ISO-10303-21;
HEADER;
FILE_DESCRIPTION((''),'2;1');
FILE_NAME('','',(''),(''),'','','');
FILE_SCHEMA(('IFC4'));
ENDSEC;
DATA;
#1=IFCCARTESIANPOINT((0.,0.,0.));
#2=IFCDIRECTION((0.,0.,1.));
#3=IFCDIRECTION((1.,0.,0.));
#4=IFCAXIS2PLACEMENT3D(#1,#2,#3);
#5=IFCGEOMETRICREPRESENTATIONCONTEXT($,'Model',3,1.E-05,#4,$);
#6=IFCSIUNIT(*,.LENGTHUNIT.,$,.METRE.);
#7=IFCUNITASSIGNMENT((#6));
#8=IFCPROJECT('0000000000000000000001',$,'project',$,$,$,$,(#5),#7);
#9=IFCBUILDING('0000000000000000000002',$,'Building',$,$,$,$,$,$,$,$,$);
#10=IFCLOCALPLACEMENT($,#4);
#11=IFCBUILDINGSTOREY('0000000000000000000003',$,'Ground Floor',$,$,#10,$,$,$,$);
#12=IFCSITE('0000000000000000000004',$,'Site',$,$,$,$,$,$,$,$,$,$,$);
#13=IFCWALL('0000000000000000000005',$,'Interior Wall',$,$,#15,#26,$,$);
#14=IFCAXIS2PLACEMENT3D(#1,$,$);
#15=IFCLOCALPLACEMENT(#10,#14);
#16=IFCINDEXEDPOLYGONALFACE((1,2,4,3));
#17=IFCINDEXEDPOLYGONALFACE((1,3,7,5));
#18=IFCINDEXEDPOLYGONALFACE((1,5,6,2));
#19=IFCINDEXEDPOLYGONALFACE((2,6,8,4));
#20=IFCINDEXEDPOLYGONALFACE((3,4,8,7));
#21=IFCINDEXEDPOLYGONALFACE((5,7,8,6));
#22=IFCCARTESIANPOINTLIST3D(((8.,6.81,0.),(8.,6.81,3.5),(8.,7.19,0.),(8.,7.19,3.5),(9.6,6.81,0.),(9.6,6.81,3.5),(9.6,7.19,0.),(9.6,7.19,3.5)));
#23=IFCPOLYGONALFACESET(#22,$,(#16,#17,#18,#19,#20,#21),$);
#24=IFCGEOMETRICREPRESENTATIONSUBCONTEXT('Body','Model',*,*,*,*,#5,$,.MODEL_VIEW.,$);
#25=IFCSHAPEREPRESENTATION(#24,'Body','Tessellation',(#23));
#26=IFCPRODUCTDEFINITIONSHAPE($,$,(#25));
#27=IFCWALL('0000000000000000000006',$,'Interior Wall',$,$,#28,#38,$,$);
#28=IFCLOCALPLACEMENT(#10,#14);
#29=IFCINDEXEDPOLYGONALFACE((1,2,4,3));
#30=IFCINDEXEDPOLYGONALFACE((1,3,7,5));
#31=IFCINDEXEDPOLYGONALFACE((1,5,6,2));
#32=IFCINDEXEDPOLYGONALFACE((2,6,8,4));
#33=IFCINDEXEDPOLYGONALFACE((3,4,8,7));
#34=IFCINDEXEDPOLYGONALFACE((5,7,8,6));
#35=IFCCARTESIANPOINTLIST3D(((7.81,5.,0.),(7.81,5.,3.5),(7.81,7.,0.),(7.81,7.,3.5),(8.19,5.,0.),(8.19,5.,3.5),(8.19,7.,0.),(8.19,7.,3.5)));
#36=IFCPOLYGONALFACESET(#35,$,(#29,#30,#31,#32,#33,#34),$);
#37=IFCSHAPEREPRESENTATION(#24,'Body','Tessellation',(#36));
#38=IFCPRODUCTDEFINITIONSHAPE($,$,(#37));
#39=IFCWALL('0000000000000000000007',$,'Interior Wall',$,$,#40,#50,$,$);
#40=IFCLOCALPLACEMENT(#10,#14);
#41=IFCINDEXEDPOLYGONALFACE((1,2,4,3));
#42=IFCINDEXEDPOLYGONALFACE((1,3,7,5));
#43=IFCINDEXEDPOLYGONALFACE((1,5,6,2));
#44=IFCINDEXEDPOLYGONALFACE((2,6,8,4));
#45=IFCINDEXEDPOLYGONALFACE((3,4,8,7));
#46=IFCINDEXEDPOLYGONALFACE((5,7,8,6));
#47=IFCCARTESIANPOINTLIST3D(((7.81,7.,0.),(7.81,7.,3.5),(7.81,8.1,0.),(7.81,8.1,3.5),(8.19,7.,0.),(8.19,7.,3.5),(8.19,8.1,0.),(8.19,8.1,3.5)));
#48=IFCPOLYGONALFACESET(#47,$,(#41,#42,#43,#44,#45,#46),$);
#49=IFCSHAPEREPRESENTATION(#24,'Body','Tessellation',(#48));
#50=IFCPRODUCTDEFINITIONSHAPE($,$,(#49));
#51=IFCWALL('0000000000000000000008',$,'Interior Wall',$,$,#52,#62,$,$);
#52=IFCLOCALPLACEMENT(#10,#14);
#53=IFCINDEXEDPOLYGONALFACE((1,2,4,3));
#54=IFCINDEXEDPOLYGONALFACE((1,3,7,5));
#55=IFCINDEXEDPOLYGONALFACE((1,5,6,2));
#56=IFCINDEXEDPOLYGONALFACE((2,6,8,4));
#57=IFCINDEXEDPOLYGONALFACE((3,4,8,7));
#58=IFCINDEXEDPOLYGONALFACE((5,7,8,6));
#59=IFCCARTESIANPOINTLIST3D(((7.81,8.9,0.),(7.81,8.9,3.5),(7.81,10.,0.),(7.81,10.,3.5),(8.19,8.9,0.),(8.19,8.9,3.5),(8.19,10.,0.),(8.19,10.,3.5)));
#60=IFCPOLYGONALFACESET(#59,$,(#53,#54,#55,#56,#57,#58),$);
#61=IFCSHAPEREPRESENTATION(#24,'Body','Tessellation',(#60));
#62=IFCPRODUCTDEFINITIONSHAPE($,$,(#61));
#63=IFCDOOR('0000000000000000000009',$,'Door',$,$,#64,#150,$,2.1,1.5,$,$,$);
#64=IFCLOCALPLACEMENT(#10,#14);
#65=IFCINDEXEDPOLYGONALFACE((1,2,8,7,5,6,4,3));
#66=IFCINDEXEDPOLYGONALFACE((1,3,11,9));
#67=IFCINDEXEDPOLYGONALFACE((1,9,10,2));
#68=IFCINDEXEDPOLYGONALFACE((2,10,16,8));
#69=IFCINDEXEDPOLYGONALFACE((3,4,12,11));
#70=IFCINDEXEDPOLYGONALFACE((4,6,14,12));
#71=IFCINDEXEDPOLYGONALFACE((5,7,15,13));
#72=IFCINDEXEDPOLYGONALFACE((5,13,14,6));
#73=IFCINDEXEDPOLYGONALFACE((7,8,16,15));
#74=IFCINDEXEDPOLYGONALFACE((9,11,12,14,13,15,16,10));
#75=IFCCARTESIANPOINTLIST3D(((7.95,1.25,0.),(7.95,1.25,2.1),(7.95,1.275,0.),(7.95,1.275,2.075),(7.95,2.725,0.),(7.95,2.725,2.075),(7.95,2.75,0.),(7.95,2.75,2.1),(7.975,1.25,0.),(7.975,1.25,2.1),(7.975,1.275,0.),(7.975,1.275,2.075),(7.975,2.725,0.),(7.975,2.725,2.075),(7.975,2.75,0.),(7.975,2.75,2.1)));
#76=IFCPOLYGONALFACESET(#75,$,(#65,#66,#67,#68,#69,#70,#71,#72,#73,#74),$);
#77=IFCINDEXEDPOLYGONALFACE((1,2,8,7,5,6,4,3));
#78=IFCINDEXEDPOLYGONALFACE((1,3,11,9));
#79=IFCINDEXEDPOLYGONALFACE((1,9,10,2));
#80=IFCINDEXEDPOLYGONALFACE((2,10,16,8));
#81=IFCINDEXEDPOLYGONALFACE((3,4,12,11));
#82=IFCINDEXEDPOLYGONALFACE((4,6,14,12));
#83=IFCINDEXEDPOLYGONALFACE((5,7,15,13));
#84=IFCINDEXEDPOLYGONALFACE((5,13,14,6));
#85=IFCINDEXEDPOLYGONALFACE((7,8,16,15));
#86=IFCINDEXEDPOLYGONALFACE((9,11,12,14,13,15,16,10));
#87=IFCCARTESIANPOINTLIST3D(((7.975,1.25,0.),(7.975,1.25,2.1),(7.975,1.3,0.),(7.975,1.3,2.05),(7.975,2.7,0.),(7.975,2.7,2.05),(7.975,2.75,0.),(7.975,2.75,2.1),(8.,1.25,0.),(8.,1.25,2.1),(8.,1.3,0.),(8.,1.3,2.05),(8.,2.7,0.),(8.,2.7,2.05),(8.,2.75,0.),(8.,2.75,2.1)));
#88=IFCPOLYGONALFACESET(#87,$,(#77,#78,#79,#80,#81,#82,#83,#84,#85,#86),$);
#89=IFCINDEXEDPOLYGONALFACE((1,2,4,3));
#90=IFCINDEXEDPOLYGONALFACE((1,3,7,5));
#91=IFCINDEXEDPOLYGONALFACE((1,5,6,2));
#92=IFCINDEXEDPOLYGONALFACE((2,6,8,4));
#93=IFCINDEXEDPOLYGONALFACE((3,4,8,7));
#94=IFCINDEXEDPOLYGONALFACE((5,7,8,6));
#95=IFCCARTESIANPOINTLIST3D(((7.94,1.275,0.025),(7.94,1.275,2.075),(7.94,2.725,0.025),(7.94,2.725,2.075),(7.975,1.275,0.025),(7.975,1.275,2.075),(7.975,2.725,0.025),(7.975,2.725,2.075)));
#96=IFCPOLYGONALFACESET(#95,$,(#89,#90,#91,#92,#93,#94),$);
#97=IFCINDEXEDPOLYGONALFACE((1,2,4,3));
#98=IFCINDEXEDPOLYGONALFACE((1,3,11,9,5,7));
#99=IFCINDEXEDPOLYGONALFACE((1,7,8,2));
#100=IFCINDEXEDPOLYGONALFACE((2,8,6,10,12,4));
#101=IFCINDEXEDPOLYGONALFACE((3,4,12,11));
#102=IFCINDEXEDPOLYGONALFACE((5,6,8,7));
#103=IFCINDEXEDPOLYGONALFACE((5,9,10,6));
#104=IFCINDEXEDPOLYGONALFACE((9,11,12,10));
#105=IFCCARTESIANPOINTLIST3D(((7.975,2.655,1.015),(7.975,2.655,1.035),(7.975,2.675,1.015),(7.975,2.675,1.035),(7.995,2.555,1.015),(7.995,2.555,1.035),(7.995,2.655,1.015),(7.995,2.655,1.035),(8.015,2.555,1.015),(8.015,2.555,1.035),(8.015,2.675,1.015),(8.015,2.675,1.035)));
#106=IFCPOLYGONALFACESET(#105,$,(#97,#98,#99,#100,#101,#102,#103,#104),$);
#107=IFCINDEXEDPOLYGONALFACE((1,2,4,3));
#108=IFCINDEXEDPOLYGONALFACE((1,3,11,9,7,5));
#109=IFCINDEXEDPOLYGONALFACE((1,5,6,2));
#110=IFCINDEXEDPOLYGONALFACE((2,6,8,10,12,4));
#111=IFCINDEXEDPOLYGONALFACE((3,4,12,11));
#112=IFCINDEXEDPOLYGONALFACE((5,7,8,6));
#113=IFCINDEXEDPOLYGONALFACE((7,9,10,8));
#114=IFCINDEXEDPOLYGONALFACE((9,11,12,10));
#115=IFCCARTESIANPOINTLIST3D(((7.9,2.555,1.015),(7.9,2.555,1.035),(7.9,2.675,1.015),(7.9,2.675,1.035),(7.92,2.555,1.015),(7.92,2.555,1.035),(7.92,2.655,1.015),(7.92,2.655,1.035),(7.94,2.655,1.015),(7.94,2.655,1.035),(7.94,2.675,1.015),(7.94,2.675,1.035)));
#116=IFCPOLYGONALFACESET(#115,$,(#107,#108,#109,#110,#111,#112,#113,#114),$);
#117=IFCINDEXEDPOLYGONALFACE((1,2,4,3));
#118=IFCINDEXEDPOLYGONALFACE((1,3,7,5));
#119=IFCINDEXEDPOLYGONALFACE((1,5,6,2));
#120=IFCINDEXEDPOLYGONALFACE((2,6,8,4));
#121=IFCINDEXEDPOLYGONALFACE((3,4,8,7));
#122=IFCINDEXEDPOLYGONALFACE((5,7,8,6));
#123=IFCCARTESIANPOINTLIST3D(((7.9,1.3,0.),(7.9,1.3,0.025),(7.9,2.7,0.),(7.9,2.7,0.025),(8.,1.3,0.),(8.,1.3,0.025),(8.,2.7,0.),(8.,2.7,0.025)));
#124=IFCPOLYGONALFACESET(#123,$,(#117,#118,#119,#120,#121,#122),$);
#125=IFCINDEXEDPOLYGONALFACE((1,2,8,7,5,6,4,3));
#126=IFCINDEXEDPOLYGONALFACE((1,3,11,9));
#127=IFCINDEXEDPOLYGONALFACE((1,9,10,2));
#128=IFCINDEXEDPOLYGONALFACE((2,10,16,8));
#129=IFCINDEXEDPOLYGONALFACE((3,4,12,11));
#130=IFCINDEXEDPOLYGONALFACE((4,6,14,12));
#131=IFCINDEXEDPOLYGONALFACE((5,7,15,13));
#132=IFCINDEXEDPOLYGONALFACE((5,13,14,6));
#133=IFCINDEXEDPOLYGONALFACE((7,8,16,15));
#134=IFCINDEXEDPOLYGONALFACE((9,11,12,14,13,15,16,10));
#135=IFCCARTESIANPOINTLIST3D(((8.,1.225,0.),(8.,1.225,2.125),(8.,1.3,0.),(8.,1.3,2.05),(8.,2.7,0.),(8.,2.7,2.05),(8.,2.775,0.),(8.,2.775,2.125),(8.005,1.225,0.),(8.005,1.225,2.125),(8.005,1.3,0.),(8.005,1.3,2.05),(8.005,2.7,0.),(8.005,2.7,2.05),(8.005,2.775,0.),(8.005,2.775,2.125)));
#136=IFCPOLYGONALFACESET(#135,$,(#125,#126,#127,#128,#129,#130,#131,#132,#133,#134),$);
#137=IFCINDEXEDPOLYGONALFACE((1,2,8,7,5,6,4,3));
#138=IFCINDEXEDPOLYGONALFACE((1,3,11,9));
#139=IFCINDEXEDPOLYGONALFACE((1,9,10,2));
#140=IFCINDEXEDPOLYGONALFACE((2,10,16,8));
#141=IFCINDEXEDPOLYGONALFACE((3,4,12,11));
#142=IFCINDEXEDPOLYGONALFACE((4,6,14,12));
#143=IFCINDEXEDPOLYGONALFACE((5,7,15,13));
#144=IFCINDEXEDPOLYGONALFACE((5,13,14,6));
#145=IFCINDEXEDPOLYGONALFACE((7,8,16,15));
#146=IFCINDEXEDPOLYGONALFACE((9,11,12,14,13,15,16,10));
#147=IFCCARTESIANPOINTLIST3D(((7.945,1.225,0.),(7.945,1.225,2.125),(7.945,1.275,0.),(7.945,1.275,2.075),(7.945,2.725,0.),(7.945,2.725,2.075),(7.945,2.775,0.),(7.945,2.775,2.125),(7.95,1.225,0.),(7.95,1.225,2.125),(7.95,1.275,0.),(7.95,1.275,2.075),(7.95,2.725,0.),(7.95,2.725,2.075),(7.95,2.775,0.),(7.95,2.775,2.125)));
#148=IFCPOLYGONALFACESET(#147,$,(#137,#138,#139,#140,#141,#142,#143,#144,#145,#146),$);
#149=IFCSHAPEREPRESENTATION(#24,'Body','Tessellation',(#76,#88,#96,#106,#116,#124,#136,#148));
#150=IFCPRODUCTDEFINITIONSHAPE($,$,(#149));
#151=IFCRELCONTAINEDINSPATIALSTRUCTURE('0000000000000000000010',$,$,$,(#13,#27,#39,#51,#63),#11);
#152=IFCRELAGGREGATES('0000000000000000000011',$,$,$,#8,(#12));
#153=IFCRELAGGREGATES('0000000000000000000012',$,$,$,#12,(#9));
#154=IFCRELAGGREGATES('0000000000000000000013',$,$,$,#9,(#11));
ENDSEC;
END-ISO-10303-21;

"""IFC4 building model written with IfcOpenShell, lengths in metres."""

from ifc_helpers import new_model, si_unit, frame, origin_with_axes, place, context, subcontext, project, spatial, line, indexed_curve, outline, extrude, element, save


model = new_model("IFC4")

# Units and contexts
model_context = context("Model", 3, precision=1e-05, world=origin_with_axes())
body_context = subcontext(model_context, "Body", "Model", "MODEL_VIEW")
ifc_project = project(units=[si_unit("LENGTHUNIT", "METRE")], contexts=[model_context])

# Site, building, storey
site = spatial("IfcSite", under=ifc_project, Name="Site")
building = spatial("IfcBuilding", under=site, Name="Building")
storey_placement = place(None, origin_with_axes())
storey = spatial("IfcBuildingStorey", under=building, at=storey_placement, Name="Ground Floor")

# Walls
for number, where, z_axis, x_axis, name in (
    (1, (9.6, 7.0, 0.0), (0.0, 0.0, 1.0), (-1.0, 0.0, 0.0), "Interior Wall"),
):
    element("IfcWall", number, at=place(storey_placement, frame(where, z_axis=z_axis, x_axis=x_axis)), inside=storey, Name=name, context=body_context, shape_type="SweptSolid", body=[
        extrude(outline(indexed_curve([(0.0, 0.0), (0.0, 0.38), (1.6, 0.38), (1.6, 0.0), (0.0, 0.0)], self_intersect=False)), frame((0.0, -0.19, 0.0), z_axis=(0.0, 0.0, 1.0), x_axis=(1.0, 0.0, 0.0)), (0.0, 0.0, 1.0), 3.5),
    ])
wall_1_placement = place(storey_placement, frame((8.0, 7.0, 0.0), z_axis=(0.0, 0.0, 1.0), x_axis=(0.0, -1.0, 0.0)))
element("IfcWall", 2, at=wall_1_placement, inside=storey, Name="Interior Wall", context=body_context, shape_type="SweptSolid", body=[
    extrude(outline(indexed_curve([(0.0, 0.0), (0.0, 0.38), (2.0, 0.38), (2.0, 0.0), (0.0, 0.0)], self_intersect=False)), frame((0.0, -0.19, 0.0), z_axis=(0.0, 0.0, 1.0), x_axis=(1.0, 0.0, 0.0)), (0.0, 0.0, 1.0), 3.5),
])
for number, where, z_axis, x_axis, name in (
    (3, (8.0, 7.0, 0.0), (0.0, 0.0, 1.0), (0.0, 1.0, 0.0), "Interior Wall"),
    (4, (8.0, 8.9, 0.0), (0.0, 0.0, 1.0), (0.0, 1.0, 0.0), "Interior Wall"),
):
    element("IfcWall", number, at=place(storey_placement, frame(where, z_axis=z_axis, x_axis=x_axis)), inside=storey, Name=name, context=body_context, shape_type="SweptSolid", body=[
        extrude(outline(indexed_curve([(0.0, 0.0), (0.0, 0.38), (1.1, 0.38), (1.1, 0.0), (0.0, 0.0)], self_intersect=False)), frame((0.0, -0.19, 0.0), z_axis=(0.0, 0.0, 1.0), x_axis=(1.0, 0.0, 0.0)), (0.0, 0.0, 1.0), 3.5),
    ])

# Door
door_1_placement = place(storey_placement, frame((8.0, 1.25, 0.0), z_axis=(0.0, 0.0, 1.0), x_axis=(0.0, 1.0, 0.0)))
element("IfcDoor", 5, at=door_1_placement, inside=storey, Name="Door", OverallHeight=2.1, OverallWidth=1.5, context=body_context, shape_type="SweptSolid", body=[
    extrude(outline(indexed_curve([(0.0, 0.0), (0.0, 2.1), (1.5, 2.1), (1.5, 0.0), (1.475, 0.0), (1.475, 2.075), (0.025, 2.075), (0.025, 0.0)], segments=[line(1, 2, 3, 4, 5, 6, 7, 8, 1)])), frame((0.0, 0.025, 0.0), z_axis=(0.0, -1.0, 0.0), x_axis=(1.0, 0.0, 0.0)), (0.0, 0.0, -1.0), 0.025),
    extrude(outline(indexed_curve([(0.0, 0.0), (0.0, 2.1), (1.5, 2.1), (1.5, 0.0), (1.45, 0.0), (1.45, 2.05), (0.05, 2.05), (0.05, 0.0)], segments=[line(1, 2, 3, 4, 5, 6, 7, 8, 1)])), frame((0.0, 0.0, 0.0), z_axis=(0.0, -1.0, 0.0), x_axis=(1.0, 0.0, 0.0)), (0.0, 0.0, -1.0), 0.025),
    extrude(outline(indexed_curve([(0.0, 0.0), (1.45, 0.0), (1.45, 0.035), (0.0, 0.035)], segments=[line(1, 2, 3, 4, 1)])), frame((0.025, 0.025, 0.025), z_axis=(0.0, 0.0, 1.0), x_axis=(1.0, 0.0, 0.0)), (0.0, 0.0, 1.0), 2.05),
    extrude(outline(indexed_curve([(0.0, 0.0), (0.0, -0.04), (-0.12, -0.04), (-0.12, -0.02), (-0.02, -0.02), (-0.02, 0.0)], segments=[line(1, 2, 3, 4, 5, 6, 1)])), frame((1.425, 0.025, 1.015), z_axis=(0.0, 0.0, 1.0), x_axis=(1.0, 0.0, 0.0)), (0.0, 0.0, 1.0), 0.02),
    extrude(outline(indexed_curve([(0.0, 0.0), (0.0, 0.04), (-0.12, 0.04), (-0.12, 0.02), (-0.02, 0.02), (-0.02, 0.0)], segments=[line(1, 2, 3, 4, 5, 6, 1)])), frame((1.425, 0.06, 1.015), z_axis=(0.0, 0.0, 1.0), x_axis=(1.0, 0.0, 0.0)), (0.0, 0.0, 1.0), 0.02),
    extrude(outline(indexed_curve([(0.0, 0.0), (1.4, 0.0), (1.4, 0.1), (0.0, 0.1)], segments=[line(1, 2, 3, 4, 1)])), frame((0.05, 0.0, 0.0), z_axis=(0.0, 0.0, 1.0), x_axis=(1.0, 0.0, 0.0)), (0.0, 0.0, 1.0), 0.025),
    extrude(outline(indexed_curve([(0.0, 0.0), (0.0, 2.125), (1.55, 2.125), (1.55, 0.0), (1.475, 0.0), (1.475, 2.05), (0.075, 2.05), (0.075, 0.0)], segments=[line(1, 2, 3, 4, 5, 6, 7, 8, 1)])), frame((-0.025, -0.005, 0.0), z_axis=(0.0, -1.0, 0.0), x_axis=(1.0, 0.0, 0.0)), (0.0, 0.0, -1.0), 0.005),
    extrude(outline(indexed_curve([(0.0, 0.0), (0.0, 2.125), (1.55, 2.125), (1.55, 0.0), (1.5, 0.0), (1.5, 2.075), (0.05, 2.075), (0.05, 0.0)], segments=[line(1, 2, 3, 4, 5, 6, 7, 8, 1)])), frame((-0.025, 0.05, 0.0), z_axis=(0.0, -1.0, 0.0), x_axis=(1.0, 0.0, 0.0)), (0.0, 0.0, -1.0), 0.005),
])

save(model, "model.ifc")
